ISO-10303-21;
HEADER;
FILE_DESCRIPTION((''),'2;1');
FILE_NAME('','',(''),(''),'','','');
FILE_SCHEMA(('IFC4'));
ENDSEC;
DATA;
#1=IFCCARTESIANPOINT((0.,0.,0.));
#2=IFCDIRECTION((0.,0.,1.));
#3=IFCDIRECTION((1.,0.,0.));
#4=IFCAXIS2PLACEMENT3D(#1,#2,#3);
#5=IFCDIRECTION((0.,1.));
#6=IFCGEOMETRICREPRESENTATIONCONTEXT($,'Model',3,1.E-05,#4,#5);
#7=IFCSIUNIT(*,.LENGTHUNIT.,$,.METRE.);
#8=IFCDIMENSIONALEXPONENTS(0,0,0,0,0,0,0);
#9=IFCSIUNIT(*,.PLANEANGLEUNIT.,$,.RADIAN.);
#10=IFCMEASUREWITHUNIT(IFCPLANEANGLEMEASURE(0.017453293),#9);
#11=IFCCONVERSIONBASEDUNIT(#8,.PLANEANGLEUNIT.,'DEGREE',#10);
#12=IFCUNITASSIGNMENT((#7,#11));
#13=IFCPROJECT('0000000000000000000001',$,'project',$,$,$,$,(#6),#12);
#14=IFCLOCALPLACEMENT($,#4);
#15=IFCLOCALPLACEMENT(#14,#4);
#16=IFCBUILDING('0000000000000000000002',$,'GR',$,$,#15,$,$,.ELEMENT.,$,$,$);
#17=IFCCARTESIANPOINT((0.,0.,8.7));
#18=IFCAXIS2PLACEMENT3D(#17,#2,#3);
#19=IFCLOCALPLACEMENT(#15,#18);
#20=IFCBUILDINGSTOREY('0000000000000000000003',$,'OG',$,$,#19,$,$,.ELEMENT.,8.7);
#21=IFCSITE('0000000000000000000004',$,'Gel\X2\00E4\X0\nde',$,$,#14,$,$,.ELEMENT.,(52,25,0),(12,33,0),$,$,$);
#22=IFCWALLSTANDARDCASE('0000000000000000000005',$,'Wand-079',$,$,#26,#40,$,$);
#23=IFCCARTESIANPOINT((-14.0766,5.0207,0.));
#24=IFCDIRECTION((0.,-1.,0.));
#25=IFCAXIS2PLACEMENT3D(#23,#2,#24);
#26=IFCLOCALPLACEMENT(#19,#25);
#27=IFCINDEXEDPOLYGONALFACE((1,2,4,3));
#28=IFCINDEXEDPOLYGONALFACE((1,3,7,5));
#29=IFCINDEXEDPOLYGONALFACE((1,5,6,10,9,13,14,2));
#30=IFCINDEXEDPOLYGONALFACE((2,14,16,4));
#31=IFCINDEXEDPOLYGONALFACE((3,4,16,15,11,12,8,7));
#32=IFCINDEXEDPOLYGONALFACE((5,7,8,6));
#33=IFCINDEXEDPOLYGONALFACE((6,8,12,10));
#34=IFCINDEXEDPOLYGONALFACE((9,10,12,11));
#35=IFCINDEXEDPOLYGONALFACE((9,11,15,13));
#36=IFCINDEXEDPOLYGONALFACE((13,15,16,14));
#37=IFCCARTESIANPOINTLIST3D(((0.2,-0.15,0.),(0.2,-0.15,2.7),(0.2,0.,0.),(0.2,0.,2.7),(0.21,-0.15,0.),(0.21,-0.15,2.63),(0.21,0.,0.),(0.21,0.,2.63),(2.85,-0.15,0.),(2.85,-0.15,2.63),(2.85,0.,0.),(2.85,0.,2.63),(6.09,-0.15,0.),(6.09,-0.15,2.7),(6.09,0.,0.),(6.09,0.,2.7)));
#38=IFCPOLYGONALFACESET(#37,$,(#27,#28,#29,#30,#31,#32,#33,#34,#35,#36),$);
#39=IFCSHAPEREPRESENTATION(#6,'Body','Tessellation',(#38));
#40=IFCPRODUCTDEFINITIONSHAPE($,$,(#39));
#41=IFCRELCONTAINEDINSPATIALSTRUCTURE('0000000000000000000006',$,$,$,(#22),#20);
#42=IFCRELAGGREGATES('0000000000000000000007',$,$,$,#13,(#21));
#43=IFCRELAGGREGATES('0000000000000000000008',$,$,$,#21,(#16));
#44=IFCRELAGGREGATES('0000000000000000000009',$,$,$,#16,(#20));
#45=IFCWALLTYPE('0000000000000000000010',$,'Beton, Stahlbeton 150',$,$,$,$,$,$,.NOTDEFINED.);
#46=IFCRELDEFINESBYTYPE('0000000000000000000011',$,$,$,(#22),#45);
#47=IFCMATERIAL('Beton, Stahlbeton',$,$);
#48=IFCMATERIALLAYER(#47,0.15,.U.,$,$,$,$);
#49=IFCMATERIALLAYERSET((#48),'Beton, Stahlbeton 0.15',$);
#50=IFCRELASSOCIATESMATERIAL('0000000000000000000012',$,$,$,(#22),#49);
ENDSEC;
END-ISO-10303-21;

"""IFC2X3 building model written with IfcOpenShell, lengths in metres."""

from ifc_helpers import new_model, entity, si_unit, converted_unit, direction, frame, origin_with_axes, origin_2d_with_axis, place, context, project, spatial, polyline, rectangle, outline, extrude, material, layer, layer_set, layer_usage, type_object, element, save


model = new_model("IFC2X3")

# Units and contexts
model_context = context("Model", 3, precision=1e-05, world=origin_with_axes(), true_north=direction((0.0, 1.0)))
ifc_project = project(units=[si_unit("LENGTHUNIT", "METRE"), converted_unit("PLANEANGLEUNIT", "DEGREE", entity("IfcPlaneAngleMeasure", 0.017453293), si_unit("PLANEANGLEUNIT", "RADIAN"), dimensions=[0, 0, 0, 0, 0, 0, 0])], contexts=[model_context])

# Site, building, storey
site_placement = place(None, origin_with_axes())
site = spatial("IfcSite", under=ifc_project, at=site_placement, Name="Gelände", CompositionType="ELEMENT", RefLatitude=(52, 25, 0), RefLongitude=(12, 33, 0))
building_placement = place(site_placement, origin_with_axes())
building = spatial("IfcBuilding", under=site, at=building_placement, Name="GR", CompositionType="ELEMENT")
storey_placement = place(building_placement, frame((0.0, 0.0, 8.7), z_axis=(0.0, 0.0, 1.0), x_axis=(1.0, 0.0, 0.0)))
storey = spatial("IfcBuildingStorey", under=building, at=storey_placement, Name="OG", CompositionType="ELEMENT", Elevation=8.7)

# Shared definitions
ifc_material_1 = material(Name="Beton, Stahlbeton")

# Shared definitions
ifc_layer_1 = layer(ifc_material_1, 0.15, ventilated="UNKNOWN")
ifc_layer_set_1 = layer_set([ifc_layer_1], Name="Beton, Stahlbeton 0.15")
wall_type_1 = type_object("IfcWallType", Name="Beton, Stahlbeton 150", PredefinedType="NOTDEFINED")

# Wall, opening
ifc_layer_usage_1 = layer_usage(ifc_layer_set_1, "AXIS2", "NEGATIVE", 0.0)
wall_1_placement = place(storey_placement, frame((-14.0766, 5.0207, 0.0), z_axis=(0.0, 0.0, 1.0), x_axis=(0.0, -1.0, 0.0)))
wall_1 = element("IfcWallStandardCase", 1, at=wall_1_placement, inside=storey, type_object=wall_type_1, material=ifc_layer_usage_1, Name="Wand-079", context=model_context, shape_type="SweptSolid", body=[
    extrude(outline(polyline([(0.2, -0.15), (6.09, -0.15), (6.09, 0.0), (0.2, 0.0), (0.2, -0.15)])), origin_with_axes(), (0.0, 0.0, 1.0), 2.7),
])
opening_1_placement = place(wall_1_placement, frame((1.53, 0.0, 0.0), z_axis=(0.0, 0.0, 1.0), x_axis=(1.0, 0.0, 0.0)))
element("IfcOpeningElement", 2, at=opening_1_placement, cuts=wall_1, context=model_context, shape_type="SweptSolid", body=[
    extrude(rectangle(XDim=2.64, YDim=2.63, at=origin_2d_with_axis()), frame((0.0, 0.001, 1.315), z_axis=(0.0, -1.0, 0.0), x_axis=(1.0, 0.0, 0.0)), (0.0, 0.0, 1.0), 0.452),
])

save(model, "model.ifc")
